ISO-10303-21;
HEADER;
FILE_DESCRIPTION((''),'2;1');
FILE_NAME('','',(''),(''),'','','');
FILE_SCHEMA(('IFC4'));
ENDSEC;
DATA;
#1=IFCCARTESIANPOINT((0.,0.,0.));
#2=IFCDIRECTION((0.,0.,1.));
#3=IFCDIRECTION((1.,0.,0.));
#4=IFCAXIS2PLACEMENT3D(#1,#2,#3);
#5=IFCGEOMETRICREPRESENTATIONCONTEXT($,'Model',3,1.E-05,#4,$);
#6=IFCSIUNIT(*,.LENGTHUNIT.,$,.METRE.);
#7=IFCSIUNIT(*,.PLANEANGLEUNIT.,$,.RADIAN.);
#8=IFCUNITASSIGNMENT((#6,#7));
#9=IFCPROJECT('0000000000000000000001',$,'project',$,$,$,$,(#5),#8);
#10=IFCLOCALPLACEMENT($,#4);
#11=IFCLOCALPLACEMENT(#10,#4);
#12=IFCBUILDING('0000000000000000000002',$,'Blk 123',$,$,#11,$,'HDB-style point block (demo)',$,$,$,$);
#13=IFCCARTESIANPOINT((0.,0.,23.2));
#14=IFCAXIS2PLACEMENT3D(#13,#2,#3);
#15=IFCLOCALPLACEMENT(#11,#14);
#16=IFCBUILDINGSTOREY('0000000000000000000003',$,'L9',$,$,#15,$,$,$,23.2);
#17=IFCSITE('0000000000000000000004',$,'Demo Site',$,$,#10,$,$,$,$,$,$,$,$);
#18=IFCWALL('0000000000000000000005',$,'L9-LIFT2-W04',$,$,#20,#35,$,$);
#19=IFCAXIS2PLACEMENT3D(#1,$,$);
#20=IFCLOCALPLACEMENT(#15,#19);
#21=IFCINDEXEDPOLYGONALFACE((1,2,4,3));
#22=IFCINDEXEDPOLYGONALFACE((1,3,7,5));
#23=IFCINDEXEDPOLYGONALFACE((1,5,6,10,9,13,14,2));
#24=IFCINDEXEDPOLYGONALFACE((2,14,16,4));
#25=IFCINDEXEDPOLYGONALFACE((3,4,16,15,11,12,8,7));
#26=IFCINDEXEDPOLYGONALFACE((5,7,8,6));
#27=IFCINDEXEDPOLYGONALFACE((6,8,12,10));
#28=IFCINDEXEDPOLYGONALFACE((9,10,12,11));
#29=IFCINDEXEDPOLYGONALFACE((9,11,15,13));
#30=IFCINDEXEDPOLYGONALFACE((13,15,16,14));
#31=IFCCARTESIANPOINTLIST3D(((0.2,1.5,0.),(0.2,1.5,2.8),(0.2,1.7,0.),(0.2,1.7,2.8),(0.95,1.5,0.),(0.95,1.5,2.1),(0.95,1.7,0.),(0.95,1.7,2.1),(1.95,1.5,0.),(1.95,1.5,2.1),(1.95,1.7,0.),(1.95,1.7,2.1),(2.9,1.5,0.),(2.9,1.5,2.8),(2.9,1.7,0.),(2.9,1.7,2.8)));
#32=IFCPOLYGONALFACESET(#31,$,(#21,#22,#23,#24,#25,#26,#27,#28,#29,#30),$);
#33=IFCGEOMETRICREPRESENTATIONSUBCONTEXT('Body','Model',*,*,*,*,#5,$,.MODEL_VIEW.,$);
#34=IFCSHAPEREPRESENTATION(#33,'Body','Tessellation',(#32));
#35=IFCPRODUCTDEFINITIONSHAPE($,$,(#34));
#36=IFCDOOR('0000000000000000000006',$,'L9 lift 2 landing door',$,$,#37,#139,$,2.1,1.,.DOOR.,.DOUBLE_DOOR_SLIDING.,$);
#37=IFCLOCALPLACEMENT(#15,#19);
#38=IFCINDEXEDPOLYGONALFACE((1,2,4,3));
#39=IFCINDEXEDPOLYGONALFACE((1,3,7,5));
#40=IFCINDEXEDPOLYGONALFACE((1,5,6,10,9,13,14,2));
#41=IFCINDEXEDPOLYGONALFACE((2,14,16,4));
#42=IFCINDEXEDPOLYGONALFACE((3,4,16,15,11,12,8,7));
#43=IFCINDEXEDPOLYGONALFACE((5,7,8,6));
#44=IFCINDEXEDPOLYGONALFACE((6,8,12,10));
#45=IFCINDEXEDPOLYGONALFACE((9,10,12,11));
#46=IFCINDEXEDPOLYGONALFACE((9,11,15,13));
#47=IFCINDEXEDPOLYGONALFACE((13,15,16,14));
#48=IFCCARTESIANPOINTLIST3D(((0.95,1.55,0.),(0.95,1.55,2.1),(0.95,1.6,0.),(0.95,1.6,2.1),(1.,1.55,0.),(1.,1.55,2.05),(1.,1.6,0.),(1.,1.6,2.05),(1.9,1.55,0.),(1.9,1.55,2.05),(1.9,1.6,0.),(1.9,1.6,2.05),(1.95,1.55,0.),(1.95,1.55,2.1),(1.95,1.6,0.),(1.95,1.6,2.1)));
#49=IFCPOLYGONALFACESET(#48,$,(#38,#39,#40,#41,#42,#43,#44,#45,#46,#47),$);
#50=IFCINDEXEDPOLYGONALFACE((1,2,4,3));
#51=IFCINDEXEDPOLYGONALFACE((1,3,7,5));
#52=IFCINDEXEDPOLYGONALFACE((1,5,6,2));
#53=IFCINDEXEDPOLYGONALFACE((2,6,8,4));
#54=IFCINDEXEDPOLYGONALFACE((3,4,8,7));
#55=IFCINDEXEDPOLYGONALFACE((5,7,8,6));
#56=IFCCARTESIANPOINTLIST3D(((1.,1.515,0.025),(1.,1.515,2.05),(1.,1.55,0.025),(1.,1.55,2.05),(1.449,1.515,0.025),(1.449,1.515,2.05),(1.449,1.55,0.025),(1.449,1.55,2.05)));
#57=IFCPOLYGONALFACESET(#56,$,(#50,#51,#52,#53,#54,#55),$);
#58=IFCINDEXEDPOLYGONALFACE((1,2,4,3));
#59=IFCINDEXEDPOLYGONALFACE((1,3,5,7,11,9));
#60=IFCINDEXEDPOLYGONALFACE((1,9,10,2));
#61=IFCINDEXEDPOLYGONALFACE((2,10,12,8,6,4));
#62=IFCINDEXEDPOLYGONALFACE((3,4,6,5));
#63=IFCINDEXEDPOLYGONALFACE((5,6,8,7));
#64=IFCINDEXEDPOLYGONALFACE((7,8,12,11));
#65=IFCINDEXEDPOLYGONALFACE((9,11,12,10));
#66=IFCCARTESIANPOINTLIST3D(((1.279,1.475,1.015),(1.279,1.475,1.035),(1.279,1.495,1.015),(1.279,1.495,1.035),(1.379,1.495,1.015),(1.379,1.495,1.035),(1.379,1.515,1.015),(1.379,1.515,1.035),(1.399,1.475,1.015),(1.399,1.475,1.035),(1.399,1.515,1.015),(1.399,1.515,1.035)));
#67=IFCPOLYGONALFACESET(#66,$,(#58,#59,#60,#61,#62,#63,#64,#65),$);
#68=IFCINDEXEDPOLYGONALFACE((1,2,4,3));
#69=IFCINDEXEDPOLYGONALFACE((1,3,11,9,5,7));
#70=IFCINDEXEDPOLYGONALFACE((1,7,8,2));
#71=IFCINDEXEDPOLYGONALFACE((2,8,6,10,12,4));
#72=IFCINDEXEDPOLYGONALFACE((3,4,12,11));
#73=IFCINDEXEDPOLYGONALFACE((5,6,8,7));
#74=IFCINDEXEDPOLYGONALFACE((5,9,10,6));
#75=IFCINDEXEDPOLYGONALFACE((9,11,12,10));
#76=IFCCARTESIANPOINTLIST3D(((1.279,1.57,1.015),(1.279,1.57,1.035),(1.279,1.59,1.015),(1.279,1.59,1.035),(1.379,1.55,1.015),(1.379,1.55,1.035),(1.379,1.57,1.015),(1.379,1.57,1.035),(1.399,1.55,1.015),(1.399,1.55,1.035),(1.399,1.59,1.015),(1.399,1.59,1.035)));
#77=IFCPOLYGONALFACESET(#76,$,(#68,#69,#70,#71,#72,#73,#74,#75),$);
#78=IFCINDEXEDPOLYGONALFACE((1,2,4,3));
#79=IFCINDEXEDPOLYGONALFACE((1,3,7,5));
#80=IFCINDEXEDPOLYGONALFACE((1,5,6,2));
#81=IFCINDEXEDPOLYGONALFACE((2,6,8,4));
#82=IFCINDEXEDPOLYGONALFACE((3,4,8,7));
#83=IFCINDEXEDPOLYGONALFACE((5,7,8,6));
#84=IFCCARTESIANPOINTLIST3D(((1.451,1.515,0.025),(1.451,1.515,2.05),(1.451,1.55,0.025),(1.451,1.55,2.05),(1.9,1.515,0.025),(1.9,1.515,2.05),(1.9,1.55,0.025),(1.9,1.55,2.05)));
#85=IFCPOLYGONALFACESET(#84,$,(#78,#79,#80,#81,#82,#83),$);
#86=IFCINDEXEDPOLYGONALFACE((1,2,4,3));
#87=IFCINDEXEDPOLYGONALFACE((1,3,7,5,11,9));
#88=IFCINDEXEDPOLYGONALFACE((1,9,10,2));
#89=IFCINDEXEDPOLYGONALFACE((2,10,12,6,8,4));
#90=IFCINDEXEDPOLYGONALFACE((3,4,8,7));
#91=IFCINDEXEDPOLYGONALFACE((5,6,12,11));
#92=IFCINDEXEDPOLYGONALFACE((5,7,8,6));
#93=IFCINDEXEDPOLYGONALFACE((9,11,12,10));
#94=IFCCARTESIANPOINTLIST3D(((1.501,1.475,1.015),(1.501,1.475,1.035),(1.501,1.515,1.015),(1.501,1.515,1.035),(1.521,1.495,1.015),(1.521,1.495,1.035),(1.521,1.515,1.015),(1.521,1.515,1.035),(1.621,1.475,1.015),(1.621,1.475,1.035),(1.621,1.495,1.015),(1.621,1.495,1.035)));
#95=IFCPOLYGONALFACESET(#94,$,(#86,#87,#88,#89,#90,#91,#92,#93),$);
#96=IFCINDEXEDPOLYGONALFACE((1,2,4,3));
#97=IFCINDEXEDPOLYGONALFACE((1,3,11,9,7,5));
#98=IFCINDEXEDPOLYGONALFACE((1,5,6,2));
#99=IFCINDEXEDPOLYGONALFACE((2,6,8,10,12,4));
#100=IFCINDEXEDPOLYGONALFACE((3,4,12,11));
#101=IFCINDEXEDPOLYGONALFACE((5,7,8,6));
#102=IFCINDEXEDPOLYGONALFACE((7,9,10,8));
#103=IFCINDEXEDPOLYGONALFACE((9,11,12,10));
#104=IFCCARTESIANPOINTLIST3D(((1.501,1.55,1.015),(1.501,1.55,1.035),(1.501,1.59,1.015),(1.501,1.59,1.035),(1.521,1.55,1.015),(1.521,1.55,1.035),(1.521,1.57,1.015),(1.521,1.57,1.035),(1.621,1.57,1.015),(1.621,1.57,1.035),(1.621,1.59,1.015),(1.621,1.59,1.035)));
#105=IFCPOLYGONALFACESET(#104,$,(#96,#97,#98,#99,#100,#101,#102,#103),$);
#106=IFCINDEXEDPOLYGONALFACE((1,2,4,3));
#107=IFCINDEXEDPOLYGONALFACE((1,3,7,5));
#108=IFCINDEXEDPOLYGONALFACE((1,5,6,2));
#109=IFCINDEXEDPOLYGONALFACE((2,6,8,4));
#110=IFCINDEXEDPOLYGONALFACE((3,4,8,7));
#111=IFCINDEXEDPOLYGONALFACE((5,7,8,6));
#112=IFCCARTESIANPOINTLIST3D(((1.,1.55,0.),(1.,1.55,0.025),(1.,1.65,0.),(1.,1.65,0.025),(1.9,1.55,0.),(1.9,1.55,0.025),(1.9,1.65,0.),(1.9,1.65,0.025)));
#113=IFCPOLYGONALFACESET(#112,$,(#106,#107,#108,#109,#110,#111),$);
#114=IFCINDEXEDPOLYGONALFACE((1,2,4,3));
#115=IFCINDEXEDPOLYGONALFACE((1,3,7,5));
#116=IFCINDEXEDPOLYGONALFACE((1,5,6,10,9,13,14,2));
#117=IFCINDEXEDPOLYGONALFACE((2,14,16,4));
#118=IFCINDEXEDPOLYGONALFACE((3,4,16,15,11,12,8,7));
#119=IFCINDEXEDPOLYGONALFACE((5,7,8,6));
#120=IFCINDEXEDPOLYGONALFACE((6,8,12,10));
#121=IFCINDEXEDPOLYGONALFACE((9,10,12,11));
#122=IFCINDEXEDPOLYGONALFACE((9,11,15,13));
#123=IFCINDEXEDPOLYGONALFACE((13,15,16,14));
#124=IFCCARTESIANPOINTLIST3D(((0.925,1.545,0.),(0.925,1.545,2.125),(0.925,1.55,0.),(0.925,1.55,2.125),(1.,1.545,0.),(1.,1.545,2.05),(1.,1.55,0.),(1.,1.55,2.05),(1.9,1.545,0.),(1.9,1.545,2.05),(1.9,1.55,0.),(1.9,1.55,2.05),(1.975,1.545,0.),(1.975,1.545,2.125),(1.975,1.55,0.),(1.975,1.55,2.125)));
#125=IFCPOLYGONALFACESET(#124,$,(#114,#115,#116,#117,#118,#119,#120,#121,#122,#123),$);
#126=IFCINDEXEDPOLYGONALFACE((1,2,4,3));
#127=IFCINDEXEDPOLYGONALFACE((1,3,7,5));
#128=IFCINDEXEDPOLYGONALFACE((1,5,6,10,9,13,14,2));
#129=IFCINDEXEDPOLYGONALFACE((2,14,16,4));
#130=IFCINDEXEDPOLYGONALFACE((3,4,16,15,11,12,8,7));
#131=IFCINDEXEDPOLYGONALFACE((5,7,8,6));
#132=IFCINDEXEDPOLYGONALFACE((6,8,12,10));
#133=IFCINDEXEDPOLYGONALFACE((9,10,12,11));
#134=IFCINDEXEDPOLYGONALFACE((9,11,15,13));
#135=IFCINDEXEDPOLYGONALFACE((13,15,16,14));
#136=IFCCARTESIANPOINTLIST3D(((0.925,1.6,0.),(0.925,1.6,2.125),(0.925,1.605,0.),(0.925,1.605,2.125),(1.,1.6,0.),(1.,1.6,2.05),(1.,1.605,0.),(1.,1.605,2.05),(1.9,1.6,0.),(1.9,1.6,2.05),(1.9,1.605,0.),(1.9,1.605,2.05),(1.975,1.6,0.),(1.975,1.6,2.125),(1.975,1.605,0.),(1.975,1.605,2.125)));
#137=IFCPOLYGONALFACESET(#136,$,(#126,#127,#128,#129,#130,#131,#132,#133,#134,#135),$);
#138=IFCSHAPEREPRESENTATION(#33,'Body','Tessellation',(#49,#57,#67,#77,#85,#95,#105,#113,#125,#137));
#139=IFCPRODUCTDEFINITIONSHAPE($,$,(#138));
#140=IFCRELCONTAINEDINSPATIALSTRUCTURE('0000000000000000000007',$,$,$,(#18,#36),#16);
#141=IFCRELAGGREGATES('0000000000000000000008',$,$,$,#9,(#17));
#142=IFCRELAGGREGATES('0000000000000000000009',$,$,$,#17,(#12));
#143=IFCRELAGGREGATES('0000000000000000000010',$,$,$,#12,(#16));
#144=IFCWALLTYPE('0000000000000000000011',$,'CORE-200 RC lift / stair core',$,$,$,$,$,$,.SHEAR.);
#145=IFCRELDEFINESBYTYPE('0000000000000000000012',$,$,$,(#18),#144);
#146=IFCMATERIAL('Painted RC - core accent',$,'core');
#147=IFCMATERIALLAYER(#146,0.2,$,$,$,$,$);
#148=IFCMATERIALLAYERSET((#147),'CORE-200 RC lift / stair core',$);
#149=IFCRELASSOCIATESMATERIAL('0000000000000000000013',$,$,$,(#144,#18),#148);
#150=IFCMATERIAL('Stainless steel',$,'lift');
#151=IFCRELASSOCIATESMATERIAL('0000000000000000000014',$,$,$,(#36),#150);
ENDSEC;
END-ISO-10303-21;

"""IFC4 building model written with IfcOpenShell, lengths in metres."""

from ifc_helpers import new_model, si_unit, frame, origin_with_axes, place, context, subcontext, project, spatial, line, indexed_curve, outline, extrude, material, layer, layer_set, layer_usage, type_object, element, fill, save


model = new_model("IFC4")

# Units and contexts
model_context = context("Model", 3, precision=1e-05, world=origin_with_axes())
body_context = subcontext(model_context, "Body", "Model", "MODEL_VIEW")
ifc_project = project(units=[si_unit("LENGTHUNIT", "METRE"), si_unit("PLANEANGLEUNIT", "RADIAN")], contexts=[model_context])

# Site, building, storey
site_placement = place(None, origin_with_axes())
site = spatial("IfcSite", under=ifc_project, at=site_placement, Name="Demo Site")
building_placement = place(site_placement, origin_with_axes())
building = spatial("IfcBuilding", under=site, at=building_placement, Name="Blk 123", LongName="HDB-style point block (demo)")
storey_placement = place(building_placement, frame((0.0, 0.0, 23.2), z_axis=(0.0, 0.0, 1.0), x_axis=(1.0, 0.0, 0.0)))
storey = spatial("IfcBuildingStorey", under=building, at=storey_placement, Name="L9", Elevation=23.2)

# Shared definitions
ifc_material_1 = material(Name="Painted RC - core accent", Category="core")
ifc_layer_1 = layer(ifc_material_1, 0.2)
ifc_layer_set_1 = layer_set([ifc_layer_1], Name="CORE-200 RC lift / stair core")
ifc_layer_usage_1 = layer_usage(ifc_layer_set_1, "AXIS2", "POSITIVE", 0.0)
wall_type_1 = type_object("IfcWallType", Name="CORE-200 RC lift / stair core", PredefinedType="SHEAR", material=ifc_layer_set_1)

# Wall, opening, door
wall_1_placement = place(storey_placement, frame((0.2, 1.5, 0.0), z_axis=(0.0, 0.0, 1.0), x_axis=(1.0, 0.0, 0.0)))
wall_1 = element("IfcWall", 1, at=wall_1_placement, inside=storey, type_object=wall_type_1, material=ifc_layer_usage_1, Name="L9-LIFT2-W04", context=body_context, shape_type="SweptSolid", body=[
    extrude(outline(indexed_curve([(0.0, 0.0), (0.0, 0.2), (2.7, 0.2), (2.7, 0.0), (0.0, 0.0)], self_intersect=False)), origin_with_axes(), (0.0, 0.0, 1.0), 2.8),
])
opening_1_placement = place(wall_1_placement, frame((0.75, -0.1, 0.0), z_axis=(0.0, 0.0, 1.0), x_axis=(1.0, 0.0, 0.0)))
opening_1 = element("IfcOpeningElement", 2, at=opening_1_placement, cuts=wall_1, context=body_context, shape_type="SweptSolid", body=[
    extrude(outline(indexed_curve([(0.0, 0.0), (0.0, 0.4), (1.0, 0.4), (1.0, 0.0), (0.0, 0.0)], self_intersect=False)), origin_with_axes(), (0.0, 0.0, 1.0), 2.1),
])
ifc_material_2 = material(Name="Stainless steel", Category="lift")
door_1_placement = place(opening_1_placement, frame((0.0, 0.15, 0.0), z_axis=(0.0, 0.0, 1.0), x_axis=(1.0, 0.0, 0.0)))
door_1 = element("IfcDoor", 3, at=door_1_placement, inside=storey, material=ifc_material_2, Name="L9 lift 2 landing door", OperationType="DOUBLE_DOOR_SLIDING", OverallHeight=2.1, OverallWidth=1.0, PredefinedType="DOOR", context=body_context, shape_type="SweptSolid", body=[
    extrude(outline(indexed_curve([(0.0, 0.0), (0.0, 2.1), (1.0, 2.1), (1.0, 0.0), (0.95, 0.0), (0.95, 2.05), (0.05, 2.05), (0.05, 0.0)], segments=[line(1, 2, 3, 4, 5, 6, 7, 8, 1)])), frame((0.0, 0.0, 0.0), z_axis=(0.0, -1.0, 0.0), x_axis=(1.0, 0.0, 0.0)), (0.0, 0.0, -1.0), 0.05),
    extrude(outline(indexed_curve([(0.0, 0.0), (0.449, 0.0), (0.449, 0.035), (0.0, 0.035)], segments=[line(1, 2, 3, 4, 1)])), frame((0.05, -0.035, 0.025), z_axis=(0.0, 0.0, 1.0), x_axis=(1.0, 0.0, 0.0)), (0.0, 0.0, 1.0), 2.025),
    extrude(outline(indexed_curve([(0.0, 0.0), (0.0, -0.04), (-0.12, -0.04), (-0.12, -0.02), (-0.02, -0.02), (-0.02, 0.0)], segments=[line(1, 2, 3, 4, 5, 6, 1)])), frame((0.449, -0.035, 1.015), z_axis=(0.0, 0.0, 1.0), x_axis=(1.0, 0.0, 0.0)), (0.0, 0.0, 1.0), 0.02),
    extrude(outline(indexed_curve([(0.0, 0.0), (0.0, 0.04), (-0.12, 0.04), (-0.12, 0.02), (-0.02, 0.02), (-0.02, 0.0)], segments=[line(1, 2, 3, 4, 5, 6, 1)])), frame((0.449, 0.0, 1.015), z_axis=(0.0, 0.0, 1.0), x_axis=(1.0, 0.0, 0.0)), (0.0, 0.0, 1.0), 0.02),
    extrude(outline(indexed_curve([(0.0, 0.0), (-0.449, 0.0), (-0.449, 0.035), (0.0, 0.035)], segments=[line(1, 2, 3, 4, 1)])), frame((0.95, -0.035, 0.025), z_axis=(0.0, 0.0, 1.0), x_axis=(1.0, 0.0, 0.0)), (0.0, 0.0, 1.0), 2.025),
    extrude(outline(indexed_curve([(0.0, 0.0), (0.0, -0.04), (0.12, -0.04), (0.12, -0.02), (0.02, -0.02), (0.02, 0.0)], segments=[line(1, 2, 3, 4, 5, 6, 1)])), frame((0.551, -0.035, 1.015), z_axis=(0.0, 0.0, 1.0), x_axis=(1.0, 0.0, 0.0)), (0.0, 0.0, 1.0), 0.02),
    extrude(outline(indexed_curve([(0.0, 0.0), (0.0, 0.04), (0.12, 0.04), (0.12, 0.02), (0.02, 0.02), (0.02, 0.0)], segments=[line(1, 2, 3, 4, 5, 6, 1)])), frame((0.551, 0.0, 1.015), z_axis=(0.0, 0.0, 1.0), x_axis=(1.0, 0.0, 0.0)), (0.0, 0.0, 1.0), 0.02),
    extrude(outline(indexed_curve([(0.0, 0.0), (0.9, 0.0), (0.9, 0.1), (0.0, 0.1)], segments=[line(1, 2, 3, 4, 1)])), frame((0.05, 0.0, 0.0), z_axis=(0.0, 0.0, 1.0), x_axis=(1.0, 0.0, 0.0)), (0.0, 0.0, 1.0), 0.025),
    extrude(outline(indexed_curve([(0.0, 0.0), (0.0, 2.125), (1.05, 2.125), (1.05, 0.0), (0.975, 0.0), (0.975, 2.05), (0.075, 2.05), (0.075, 0.0)], segments=[line(1, 2, 3, 4, 5, 6, 7, 8, 1)])), frame((-0.025, -0.005, 0.0), z_axis=(0.0, -1.0, 0.0), x_axis=(1.0, 0.0, 0.0)), (0.0, 0.0, -1.0), 0.005),
    extrude(outline(indexed_curve([(0.0, 0.0), (0.0, 2.125), (1.05, 2.125), (1.05, 0.0), (0.975, 0.0), (0.975, 2.05), (0.075, 2.05), (0.075, 0.0)], segments=[line(1, 2, 3, 4, 5, 6, 7, 8, 1)])), frame((-0.025, 0.05, 0.0), z_axis=(0.0, -1.0, 0.0), x_axis=(1.0, 0.0, 0.0)), (0.0, 0.0, -1.0), 0.005),
])
fill(opening_1, door_1)

save(model, "model.ifc")
